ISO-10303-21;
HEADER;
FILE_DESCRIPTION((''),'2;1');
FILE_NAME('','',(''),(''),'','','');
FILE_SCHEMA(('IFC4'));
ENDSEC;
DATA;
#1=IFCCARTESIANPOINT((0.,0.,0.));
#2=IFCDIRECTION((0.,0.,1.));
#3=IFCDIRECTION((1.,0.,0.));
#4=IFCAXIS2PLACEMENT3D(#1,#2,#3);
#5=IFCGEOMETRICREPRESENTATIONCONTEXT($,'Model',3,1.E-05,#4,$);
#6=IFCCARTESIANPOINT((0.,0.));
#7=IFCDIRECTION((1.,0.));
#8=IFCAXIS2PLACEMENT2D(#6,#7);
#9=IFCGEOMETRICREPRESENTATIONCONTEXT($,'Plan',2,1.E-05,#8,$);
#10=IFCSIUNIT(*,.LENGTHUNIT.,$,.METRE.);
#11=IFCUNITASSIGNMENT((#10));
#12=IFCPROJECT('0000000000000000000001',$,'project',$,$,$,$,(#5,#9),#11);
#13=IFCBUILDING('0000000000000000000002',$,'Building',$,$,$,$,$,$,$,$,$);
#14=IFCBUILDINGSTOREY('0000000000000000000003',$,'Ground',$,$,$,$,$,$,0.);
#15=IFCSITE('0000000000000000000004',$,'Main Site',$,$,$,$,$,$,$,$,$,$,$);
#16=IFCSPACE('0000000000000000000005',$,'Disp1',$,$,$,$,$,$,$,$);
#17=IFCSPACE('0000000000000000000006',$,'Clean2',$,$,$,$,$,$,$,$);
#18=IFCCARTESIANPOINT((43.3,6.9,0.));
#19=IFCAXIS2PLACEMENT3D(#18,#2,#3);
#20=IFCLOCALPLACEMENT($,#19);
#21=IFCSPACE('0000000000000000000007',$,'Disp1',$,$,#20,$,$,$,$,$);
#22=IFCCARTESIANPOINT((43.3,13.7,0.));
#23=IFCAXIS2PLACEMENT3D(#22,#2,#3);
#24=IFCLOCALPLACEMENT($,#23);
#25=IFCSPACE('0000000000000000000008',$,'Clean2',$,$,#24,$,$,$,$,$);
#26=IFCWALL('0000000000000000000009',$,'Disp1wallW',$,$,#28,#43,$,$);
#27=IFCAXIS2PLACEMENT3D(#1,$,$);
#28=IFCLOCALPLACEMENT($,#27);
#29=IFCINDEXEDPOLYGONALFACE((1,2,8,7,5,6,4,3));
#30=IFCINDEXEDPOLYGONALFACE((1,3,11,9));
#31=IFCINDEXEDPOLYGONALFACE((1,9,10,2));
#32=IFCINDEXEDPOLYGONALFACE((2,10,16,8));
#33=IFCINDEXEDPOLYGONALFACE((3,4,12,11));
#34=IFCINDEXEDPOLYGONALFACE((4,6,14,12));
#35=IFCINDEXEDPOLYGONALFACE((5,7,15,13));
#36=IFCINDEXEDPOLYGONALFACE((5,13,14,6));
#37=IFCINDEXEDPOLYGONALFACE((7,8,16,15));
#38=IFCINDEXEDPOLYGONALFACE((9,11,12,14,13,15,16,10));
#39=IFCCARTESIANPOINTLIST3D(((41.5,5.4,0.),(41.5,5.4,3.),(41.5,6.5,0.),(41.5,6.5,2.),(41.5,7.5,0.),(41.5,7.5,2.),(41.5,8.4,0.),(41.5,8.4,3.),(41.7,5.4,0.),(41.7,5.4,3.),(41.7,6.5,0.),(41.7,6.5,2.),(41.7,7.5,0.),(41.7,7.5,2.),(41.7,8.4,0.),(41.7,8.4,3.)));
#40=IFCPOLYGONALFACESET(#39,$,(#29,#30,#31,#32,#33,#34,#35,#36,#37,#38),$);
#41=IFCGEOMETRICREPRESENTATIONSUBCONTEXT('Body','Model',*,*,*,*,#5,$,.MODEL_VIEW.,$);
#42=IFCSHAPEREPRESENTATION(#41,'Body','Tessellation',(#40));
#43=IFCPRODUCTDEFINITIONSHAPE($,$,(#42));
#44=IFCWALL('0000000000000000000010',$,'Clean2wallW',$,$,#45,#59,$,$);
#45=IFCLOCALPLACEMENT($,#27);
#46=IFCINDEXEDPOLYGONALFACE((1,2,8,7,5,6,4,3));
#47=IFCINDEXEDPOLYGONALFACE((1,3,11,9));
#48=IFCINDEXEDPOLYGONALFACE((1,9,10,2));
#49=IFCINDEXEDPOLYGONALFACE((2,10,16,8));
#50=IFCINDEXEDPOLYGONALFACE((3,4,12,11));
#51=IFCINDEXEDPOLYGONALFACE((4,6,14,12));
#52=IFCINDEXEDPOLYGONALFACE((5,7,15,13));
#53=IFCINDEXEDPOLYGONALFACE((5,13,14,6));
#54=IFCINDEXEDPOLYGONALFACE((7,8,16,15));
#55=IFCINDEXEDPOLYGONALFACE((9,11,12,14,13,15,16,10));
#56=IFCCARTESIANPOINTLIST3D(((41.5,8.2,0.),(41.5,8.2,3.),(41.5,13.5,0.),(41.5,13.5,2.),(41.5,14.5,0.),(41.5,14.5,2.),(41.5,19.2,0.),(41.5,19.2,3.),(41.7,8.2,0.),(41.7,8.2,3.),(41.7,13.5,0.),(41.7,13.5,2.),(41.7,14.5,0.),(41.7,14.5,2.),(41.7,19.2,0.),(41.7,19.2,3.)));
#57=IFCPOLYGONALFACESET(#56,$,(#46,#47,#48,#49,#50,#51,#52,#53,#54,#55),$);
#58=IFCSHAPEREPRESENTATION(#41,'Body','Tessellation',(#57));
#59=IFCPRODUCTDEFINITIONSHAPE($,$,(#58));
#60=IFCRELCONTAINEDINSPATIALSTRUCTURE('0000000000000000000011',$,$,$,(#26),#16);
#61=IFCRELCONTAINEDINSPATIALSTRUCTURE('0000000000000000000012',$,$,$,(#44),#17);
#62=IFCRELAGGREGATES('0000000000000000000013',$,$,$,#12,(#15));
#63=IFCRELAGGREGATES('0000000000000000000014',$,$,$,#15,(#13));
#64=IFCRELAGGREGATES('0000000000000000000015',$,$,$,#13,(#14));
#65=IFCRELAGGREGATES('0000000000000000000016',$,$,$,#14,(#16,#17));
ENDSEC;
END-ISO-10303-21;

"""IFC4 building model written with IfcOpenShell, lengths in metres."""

from ifc_helpers import new_model, si_unit, frame, origin_with_axes, origin_2d_with_axis, place, context, subcontext, project, spatial, indexed_curve, outline, extrude, element, save


model = new_model("IFC4")

# Units and contexts
model_context = context("Model", 3, precision=1e-05, world=origin_with_axes())
plan_context = context("Plan", 2, precision=1e-05, world=origin_2d_with_axis())
body_context = subcontext(model_context, "Body", "Model", "MODEL_VIEW")
ifc_project = project(units=[si_unit("LENGTHUNIT", "METRE")], contexts=[model_context, plan_context])

# Site, building, storey
site = spatial("IfcSite", under=ifc_project, Name="Main Site")
building = spatial("IfcBuilding", under=site, Name="Building")
storey = spatial("IfcBuildingStorey", under=building, Name="Ground", Elevation=0.0)

# Shared definitions
space_1 = spatial("IfcSpace", under=storey, Name="Disp1")

# Shared definitions
space_2 = spatial("IfcSpace", under=storey, Name="Clean2")

# Wall
wall_1_placement = place(None, frame((41.7, 5.4, 0.0), z_axis=(0.0, 0.0, 1.0), x_axis=(0.0, 1.0, 0.0)))
wall_1 = element("IfcWall", 1, at=wall_1_placement, inside=space_1, Name="Disp1wallW", context=body_context, shape_type="SweptSolid", body=[
    extrude(outline(indexed_curve([(0.0, 0.0), (0.0, 0.2), (3.0, 0.2), (3.0, 0.0), (0.0, 0.0)], self_intersect=False)), origin_with_axes(), (0.0, 0.0, 1.0), 3.0),
])

# Shared definitions
space_3_placement = place(None, frame((43.3, 6.9, 0.0), z_axis=(0.0, 0.0, 1.0), x_axis=(1.0, 0.0, 0.0)))
space_3 = spatial("IfcSpace", at=space_3_placement, Name="Disp1")

# Opening
opening_1_placement = place(wall_1_placement, frame((1.1, 0.0, 0.0), z_axis=(0.0, 0.0, 1.0), x_axis=(1.0, 0.0, 0.0)))
element("IfcOpeningElement", 2, at=opening_1_placement, inside=space_3, cuts=wall_1, context=body_context, shape_type="SweptSolid", body=[
    extrude(outline(indexed_curve([(0.0, 0.0), (0.0, 0.4), (1.0, 0.4), (1.0, 0.0), (0.0, 0.0)], self_intersect=False)), origin_with_axes(), (0.0, 0.0, 1.0), 2.0),
])

# Wall
wall_2_placement = place(None, frame((41.7, 8.2, 0.0), z_axis=(0.0, 0.0, 1.0), x_axis=(0.0, 1.0, 0.0)))
wall_2 = element("IfcWall", 3, at=wall_2_placement, inside=space_2, Name="Clean2wallW", context=body_context, shape_type="SweptSolid", body=[
    extrude(outline(indexed_curve([(0.0, 0.0), (0.0, 0.2), (11.0, 0.2), (11.0, 0.0), (0.0, 0.0)], self_intersect=False)), origin_with_axes(), (0.0, 0.0, 1.0), 3.0),
])

# Shared definitions
space_4_placement = place(None, frame((43.3, 13.7, 0.0), z_axis=(0.0, 0.0, 1.0), x_axis=(1.0, 0.0, 0.0)))
space_4 = spatial("IfcSpace", at=space_4_placement, Name="Clean2")

# Opening
opening_2_placement = place(wall_2_placement, frame((5.3, 0.0, 0.0), z_axis=(0.0, 0.0, 1.0), x_axis=(1.0, 0.0, 0.0)))
element("IfcOpeningElement", 4, at=opening_2_placement, inside=space_4, cuts=wall_2, context=body_context, shape_type="SweptSolid", body=[
    extrude(outline(indexed_curve([(0.0, 0.0), (0.0, 0.4), (1.0, 0.4), (1.0, 0.0), (0.0, 0.0)], self_intersect=False)), origin_with_axes(), (0.0, 0.0, 1.0), 2.0),
])

save(model, "model.ifc")
